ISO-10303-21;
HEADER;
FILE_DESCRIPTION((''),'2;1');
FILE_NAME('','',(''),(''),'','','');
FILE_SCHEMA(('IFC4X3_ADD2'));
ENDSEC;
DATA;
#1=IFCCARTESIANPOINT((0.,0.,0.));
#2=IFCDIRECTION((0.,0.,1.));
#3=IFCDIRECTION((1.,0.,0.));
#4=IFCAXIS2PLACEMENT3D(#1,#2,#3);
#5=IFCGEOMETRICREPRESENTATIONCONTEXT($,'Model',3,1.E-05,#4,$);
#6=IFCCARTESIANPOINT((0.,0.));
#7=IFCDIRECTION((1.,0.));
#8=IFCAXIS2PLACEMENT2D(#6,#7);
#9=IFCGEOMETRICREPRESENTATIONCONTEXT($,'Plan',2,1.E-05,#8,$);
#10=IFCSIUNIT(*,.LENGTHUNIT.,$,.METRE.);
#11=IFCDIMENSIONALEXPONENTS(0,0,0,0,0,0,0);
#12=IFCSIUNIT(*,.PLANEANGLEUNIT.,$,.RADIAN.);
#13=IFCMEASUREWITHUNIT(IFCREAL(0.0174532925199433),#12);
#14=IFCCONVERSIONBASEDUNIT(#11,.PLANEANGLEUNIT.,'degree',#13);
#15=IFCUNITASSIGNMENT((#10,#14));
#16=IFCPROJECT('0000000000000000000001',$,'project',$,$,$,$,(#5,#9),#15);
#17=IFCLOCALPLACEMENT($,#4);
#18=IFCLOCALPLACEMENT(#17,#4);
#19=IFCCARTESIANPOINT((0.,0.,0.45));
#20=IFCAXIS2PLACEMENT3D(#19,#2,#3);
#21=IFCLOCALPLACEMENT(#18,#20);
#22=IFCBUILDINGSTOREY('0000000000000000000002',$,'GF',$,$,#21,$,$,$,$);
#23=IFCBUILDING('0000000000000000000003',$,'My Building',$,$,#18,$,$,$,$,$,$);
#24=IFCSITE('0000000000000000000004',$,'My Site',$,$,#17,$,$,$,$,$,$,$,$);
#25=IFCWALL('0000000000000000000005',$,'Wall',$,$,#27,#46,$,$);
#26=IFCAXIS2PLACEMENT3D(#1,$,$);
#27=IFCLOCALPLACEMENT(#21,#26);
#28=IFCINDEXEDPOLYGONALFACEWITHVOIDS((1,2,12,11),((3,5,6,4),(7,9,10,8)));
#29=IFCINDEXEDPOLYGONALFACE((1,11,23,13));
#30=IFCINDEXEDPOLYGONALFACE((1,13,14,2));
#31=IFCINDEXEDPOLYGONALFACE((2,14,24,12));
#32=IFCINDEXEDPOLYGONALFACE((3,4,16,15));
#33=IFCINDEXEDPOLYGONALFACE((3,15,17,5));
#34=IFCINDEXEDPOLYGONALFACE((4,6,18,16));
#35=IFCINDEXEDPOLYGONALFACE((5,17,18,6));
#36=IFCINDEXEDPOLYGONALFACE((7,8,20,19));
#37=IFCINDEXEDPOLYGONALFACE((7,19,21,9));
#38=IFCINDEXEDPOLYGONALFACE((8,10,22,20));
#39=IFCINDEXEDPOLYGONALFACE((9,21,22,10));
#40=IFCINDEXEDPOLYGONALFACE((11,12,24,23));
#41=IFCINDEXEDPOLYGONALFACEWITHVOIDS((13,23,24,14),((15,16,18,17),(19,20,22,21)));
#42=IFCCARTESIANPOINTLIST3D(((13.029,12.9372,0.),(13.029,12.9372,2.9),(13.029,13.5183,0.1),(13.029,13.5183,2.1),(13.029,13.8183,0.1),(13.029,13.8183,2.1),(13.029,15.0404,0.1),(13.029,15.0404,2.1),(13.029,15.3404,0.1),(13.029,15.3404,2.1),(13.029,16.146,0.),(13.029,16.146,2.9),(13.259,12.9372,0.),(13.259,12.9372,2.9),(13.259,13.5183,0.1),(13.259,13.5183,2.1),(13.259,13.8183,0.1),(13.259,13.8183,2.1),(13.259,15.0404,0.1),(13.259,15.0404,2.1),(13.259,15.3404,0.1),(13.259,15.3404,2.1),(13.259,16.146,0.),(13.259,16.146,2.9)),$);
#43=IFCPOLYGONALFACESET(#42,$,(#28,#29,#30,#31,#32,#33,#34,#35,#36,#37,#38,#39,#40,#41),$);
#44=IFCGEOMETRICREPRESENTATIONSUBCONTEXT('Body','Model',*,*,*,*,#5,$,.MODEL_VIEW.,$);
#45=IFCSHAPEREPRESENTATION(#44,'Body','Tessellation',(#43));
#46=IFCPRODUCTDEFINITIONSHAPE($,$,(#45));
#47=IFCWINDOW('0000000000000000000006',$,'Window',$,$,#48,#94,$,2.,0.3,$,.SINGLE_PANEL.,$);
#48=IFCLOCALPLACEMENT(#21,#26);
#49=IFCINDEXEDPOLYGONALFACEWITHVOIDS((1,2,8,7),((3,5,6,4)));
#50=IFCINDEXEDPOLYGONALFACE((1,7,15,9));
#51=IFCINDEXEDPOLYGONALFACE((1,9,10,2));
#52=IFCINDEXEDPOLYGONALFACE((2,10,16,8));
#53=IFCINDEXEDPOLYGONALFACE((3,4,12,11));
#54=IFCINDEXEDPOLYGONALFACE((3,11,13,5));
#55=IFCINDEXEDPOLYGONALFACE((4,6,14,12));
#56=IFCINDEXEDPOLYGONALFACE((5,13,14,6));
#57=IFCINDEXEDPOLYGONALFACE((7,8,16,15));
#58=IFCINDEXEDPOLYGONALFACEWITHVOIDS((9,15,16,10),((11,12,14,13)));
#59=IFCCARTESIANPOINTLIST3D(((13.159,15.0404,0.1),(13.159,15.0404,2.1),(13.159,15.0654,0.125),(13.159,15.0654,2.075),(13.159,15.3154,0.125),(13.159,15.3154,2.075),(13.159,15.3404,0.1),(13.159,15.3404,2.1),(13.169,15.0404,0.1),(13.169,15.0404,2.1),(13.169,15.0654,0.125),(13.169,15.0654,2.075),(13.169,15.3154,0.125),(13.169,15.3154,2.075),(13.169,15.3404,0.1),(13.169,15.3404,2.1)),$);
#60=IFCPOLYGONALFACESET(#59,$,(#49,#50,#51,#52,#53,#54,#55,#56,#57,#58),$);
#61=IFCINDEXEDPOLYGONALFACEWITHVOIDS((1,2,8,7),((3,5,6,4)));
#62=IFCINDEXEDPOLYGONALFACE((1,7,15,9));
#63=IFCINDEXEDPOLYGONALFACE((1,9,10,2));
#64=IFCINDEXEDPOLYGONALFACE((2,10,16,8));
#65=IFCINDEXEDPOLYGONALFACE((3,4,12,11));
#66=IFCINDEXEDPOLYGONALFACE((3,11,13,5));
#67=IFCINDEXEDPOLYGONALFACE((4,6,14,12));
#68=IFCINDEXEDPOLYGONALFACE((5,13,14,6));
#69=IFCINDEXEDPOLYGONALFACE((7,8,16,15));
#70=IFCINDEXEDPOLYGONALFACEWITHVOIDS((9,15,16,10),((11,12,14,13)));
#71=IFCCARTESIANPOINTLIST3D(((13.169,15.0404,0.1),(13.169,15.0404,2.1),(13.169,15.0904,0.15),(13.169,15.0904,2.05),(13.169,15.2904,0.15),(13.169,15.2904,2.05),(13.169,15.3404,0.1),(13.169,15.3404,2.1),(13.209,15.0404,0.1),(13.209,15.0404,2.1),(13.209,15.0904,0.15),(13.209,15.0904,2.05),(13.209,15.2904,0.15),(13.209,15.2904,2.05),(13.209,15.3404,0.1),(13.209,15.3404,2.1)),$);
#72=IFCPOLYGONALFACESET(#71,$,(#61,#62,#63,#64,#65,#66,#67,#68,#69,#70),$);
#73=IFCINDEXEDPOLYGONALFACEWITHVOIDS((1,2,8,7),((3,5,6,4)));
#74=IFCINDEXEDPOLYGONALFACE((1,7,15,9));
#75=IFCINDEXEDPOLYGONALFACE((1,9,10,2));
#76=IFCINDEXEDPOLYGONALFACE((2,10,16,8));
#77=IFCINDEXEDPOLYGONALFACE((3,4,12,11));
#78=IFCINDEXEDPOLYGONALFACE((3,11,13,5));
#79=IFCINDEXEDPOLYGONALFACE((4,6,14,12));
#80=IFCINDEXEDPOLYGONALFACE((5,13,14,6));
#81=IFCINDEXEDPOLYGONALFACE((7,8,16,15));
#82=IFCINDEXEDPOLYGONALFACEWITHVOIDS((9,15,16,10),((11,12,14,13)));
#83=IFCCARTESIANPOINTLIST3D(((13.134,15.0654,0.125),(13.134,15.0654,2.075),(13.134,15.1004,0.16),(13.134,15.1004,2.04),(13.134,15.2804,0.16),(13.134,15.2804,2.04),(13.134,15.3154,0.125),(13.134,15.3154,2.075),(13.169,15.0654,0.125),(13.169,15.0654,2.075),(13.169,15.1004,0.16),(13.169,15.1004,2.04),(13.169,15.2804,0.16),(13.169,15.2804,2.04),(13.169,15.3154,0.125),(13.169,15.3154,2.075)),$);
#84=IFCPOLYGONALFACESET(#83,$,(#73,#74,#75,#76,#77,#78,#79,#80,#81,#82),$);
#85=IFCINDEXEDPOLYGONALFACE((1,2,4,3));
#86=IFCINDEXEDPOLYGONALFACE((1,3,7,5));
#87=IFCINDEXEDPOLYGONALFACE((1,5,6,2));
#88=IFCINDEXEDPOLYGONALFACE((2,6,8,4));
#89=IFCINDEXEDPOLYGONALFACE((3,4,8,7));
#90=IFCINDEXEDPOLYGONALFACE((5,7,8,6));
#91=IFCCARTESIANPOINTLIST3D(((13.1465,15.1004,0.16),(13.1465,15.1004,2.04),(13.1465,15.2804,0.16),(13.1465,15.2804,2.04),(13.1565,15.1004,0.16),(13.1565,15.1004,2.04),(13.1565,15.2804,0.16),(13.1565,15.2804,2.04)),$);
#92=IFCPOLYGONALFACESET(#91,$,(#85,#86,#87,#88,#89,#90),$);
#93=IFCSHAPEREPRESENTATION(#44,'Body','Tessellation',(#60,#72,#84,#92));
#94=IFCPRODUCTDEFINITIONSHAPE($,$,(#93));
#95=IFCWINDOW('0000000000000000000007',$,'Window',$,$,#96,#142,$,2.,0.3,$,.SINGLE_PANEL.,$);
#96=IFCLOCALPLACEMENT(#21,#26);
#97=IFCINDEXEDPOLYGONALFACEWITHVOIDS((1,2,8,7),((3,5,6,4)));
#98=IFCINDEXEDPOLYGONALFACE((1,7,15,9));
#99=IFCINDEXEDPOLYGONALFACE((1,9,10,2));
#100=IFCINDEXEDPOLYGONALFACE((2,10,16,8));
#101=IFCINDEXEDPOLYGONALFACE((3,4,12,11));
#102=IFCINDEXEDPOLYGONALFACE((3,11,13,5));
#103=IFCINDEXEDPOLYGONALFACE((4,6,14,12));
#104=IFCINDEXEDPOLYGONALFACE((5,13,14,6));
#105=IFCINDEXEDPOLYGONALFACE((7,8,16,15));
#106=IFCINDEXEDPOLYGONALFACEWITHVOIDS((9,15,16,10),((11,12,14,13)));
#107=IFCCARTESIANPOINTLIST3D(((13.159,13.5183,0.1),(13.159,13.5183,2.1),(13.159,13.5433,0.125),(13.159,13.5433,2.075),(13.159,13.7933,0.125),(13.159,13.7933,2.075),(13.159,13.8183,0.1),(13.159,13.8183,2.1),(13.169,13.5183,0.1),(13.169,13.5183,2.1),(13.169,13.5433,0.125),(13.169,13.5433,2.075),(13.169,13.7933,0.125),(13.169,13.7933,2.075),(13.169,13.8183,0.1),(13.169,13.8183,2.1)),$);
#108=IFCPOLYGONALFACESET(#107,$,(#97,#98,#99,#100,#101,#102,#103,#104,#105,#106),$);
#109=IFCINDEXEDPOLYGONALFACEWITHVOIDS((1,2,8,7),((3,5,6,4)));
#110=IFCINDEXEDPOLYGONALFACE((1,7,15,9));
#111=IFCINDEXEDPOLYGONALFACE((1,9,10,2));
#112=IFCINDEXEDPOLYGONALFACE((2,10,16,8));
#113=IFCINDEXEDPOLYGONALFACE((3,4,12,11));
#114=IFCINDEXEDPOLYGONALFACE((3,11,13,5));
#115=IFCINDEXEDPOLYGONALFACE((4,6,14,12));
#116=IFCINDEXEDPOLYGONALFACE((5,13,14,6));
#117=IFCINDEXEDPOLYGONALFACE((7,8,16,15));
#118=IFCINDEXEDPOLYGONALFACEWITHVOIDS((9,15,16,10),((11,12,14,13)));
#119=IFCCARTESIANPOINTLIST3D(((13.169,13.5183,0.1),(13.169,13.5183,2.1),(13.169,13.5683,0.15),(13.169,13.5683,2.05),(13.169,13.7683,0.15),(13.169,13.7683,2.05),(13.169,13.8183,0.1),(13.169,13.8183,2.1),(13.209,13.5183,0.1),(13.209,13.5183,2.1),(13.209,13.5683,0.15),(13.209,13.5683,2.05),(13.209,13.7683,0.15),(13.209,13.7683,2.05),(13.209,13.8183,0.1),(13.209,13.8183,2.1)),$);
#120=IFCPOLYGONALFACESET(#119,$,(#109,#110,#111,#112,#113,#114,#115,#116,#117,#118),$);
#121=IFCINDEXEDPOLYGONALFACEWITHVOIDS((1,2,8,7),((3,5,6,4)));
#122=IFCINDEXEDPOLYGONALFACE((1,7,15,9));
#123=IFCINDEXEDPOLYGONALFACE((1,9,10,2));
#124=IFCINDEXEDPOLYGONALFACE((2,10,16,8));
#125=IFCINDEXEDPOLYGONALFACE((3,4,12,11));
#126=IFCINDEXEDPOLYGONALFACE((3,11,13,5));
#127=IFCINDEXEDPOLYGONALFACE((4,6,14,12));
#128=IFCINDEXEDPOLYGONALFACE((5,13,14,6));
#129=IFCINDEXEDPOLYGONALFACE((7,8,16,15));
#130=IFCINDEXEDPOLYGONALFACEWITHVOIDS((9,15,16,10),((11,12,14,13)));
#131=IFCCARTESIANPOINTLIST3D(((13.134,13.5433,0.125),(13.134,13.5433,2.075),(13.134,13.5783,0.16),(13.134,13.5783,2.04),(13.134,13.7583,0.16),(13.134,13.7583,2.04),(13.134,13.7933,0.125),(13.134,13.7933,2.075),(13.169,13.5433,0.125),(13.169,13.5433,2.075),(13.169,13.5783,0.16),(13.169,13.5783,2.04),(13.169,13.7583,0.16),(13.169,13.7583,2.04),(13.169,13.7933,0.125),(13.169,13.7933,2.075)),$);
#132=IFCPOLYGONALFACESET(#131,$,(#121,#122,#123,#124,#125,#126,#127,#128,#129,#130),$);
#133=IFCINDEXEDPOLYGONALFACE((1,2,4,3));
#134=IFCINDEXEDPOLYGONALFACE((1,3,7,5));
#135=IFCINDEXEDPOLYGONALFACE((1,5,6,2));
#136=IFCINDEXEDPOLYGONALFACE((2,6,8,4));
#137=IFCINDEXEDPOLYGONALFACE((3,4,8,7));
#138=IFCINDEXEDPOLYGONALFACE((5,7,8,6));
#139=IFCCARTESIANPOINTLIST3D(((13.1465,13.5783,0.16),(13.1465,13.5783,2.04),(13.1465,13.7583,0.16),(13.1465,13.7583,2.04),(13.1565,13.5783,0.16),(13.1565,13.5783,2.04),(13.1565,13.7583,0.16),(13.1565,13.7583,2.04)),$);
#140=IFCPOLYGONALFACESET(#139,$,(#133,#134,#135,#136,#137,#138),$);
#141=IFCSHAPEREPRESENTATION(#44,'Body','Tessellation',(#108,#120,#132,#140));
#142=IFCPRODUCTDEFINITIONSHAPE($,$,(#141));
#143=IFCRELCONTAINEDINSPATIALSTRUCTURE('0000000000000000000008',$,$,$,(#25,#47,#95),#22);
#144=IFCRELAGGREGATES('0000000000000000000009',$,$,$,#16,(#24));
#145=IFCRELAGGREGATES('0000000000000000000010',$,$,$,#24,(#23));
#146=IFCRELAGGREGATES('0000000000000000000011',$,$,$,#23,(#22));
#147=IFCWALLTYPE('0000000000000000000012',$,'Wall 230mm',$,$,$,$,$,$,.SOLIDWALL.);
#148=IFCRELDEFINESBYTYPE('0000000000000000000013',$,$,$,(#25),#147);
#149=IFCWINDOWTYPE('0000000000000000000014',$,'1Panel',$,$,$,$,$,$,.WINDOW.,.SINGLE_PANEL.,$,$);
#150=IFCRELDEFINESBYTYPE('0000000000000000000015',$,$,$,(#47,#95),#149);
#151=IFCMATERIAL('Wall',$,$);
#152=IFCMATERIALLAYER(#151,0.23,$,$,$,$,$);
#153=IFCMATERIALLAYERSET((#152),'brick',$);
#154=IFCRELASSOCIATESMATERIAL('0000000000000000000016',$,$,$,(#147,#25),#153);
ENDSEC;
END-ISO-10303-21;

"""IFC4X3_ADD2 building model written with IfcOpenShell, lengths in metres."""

from ifc_helpers import new_model, entity, si_unit, converted_unit, frame, origin_with_axes, origin_2d_with_axis, place, context, subcontext, project, spatial, line, indexed_curve, outline, extrude, shape, source, transform, mapped, material, layer, layer_set, layer_usage, type_object, type_shapes, element, fill, save


model = new_model("IFC4X3_ADD2")

# Units and contexts
model_context = context("Model", 3, precision=1e-05, world=origin_with_axes())
plan_context = context("Plan", 2, precision=1e-05, world=origin_2d_with_axis())
body_context_1 = subcontext(model_context, "Body", "Model", "MODEL_VIEW")
body_context_2 = subcontext(plan_context, "Body", "Plan", "PLAN_VIEW")
ifc_project = project(units=[si_unit("LENGTHUNIT", "METRE"), converted_unit("PLANEANGLEUNIT", "degree", entity("IfcReal", 0.0174532925199433), si_unit("PLANEANGLEUNIT", "RADIAN"), dimensions=[0, 0, 0, 0, 0, 0, 0])], contexts=[model_context, plan_context])

# Site, building, storey
site_placement = place(None, origin_with_axes())
site = spatial("IfcSite", under=ifc_project, at=site_placement, Name="My Site")
building_placement = place(site_placement, origin_with_axes())
building = spatial("IfcBuilding", under=site, at=building_placement, Name="My Building")
storey_placement = place(building_placement, frame((0.0, 0.0, 0.45), z_axis=(0.0, 0.0, 1.0), x_axis=(1.0, 0.0, 0.0)))
storey = spatial("IfcBuildingStorey", under=building, at=storey_placement, Name="GF")

# Shared definitions
ifc_material_1 = material(Name="Wall")
ifc_layer = layer(ifc_material_1, 0.23)
ifc_layer_set = layer_set([ifc_layer], Name="brick")
wall_type = type_object("IfcWallType", Name="Wall 230mm", PredefinedType="SOLIDWALL", material=ifc_layer_set)

# Wall, openings, windows
ifc_layer_usage_1 = layer_usage(ifc_layer_set, "AXIS2", "POSITIVE", 0.0)
wall_1_placement = place(storey_placement, frame((13.259, 12.9372, 0.0), z_axis=(0.0, 0.0, 1.0), x_axis=(0.0, 1.0, 0.0)))
wall_1 = element("IfcWall", 1, at=wall_1_placement, inside=storey, type_object=wall_type, material=ifc_layer_usage_1, Name="Wall", context=body_context_1, shape_type="SweptSolid", body=[
    extrude(outline(indexed_curve([(0.0, 0.0), (0.0, 0.23), (3.2088, 0.23), (3.2088, 0.0), (0.0, 0.0)], self_intersect=False)), origin_with_axes(), (0.0, 0.0, 1.0), 2.9),
])
shared_shape_1 = source(origin_with_axes(), body_context_1, "Body", "SweptSolid", [
    extrude(outline(indexed_curve([(0.0, 0.0), (0.3, 0.0), (0.3, 2.0), (0.0, 2.0)], segments=[line(1, 2, 3, 4, 1)])), frame((0.0, -0.6, 0.0), z_axis=(0.0, -1.0, 0.0), x_axis=(1.0, 0.0, 0.0)), (0.0, 0.0, -1.0), 1.2),
])
opening_1_placement = place(wall_1_placement, frame((2.1032, 0.0, 0.1), z_axis=(0.0, 0.0, 1.0), x_axis=(1.0, 0.0, 0.0)))
opening_1 = element("IfcOpeningElement", 2, at=opening_1_placement, cuts=wall_1, PredefinedType="OPENING", context=body_context_1, shape_type="MappedRepresentation", body=[
    mapped(shared_shape_1, transform((0.0, 0.0, 0.0), x_axis=(1.0, 0.0, 0.0), y_axis=(0.0, 1.0, 0.0), z_axis=(0.0, 0.0, 1.0), scale=1.0)),
])
opening_2_placement = place(wall_1_placement, frame((0.5811, 0.0, 0.1), z_axis=(0.0, 0.0, 1.0), x_axis=(1.0, 0.0, 0.0)))
opening_2 = element("IfcOpeningElement", 3, at=opening_2_placement, cuts=wall_1, PredefinedType="OPENING", context=body_context_1, shape_type="MappedRepresentation", body=[
    mapped(shared_shape_1, transform((0.0, 0.0, 0.0), x_axis=(1.0, 0.0, 0.0), y_axis=(0.0, 1.0, 0.0), z_axis=(0.0, 0.0, 1.0), scale=1.0)),
])
window_type_1 = type_object("IfcWindowType", Name="1Panel", PartitioningType="SINGLE_PANEL", PredefinedType="WINDOW")
shared_shape_2 = source(origin_with_axes(), body_context_1, "Body", "SweptSolid", [
    extrude(outline(indexed_curve([(0.0, 0.0), (0.3, 0.0), (0.3, 2.0), (0.0, 2.0)], segments=[line(1, 2, 3, 4, 1)]), holes=[indexed_curve([(0.025, 0.025), (0.275, 0.025), (0.275, 1.975), (0.025, 1.975)], segments=[line(1, 2, 3, 4, 1)])]), frame((0.0, 0.09, 0.0), z_axis=(0.0, -1.0, 0.0), x_axis=(1.0, 0.0, 0.0)), (0.0, 0.0, -1.0), 0.01),
    extrude(outline(indexed_curve([(0.0, 0.0), (0.3, 0.0), (0.3, 2.0), (0.0, 2.0)], segments=[line(1, 2, 3, 4, 1)]), holes=[indexed_curve([(0.05, 0.05), (0.25, 0.05), (0.25, 1.95), (0.05, 1.95)], segments=[line(1, 2, 3, 4, 1)])]), frame((0.0, 0.05, 0.0), z_axis=(0.0, -1.0, 0.0), x_axis=(1.0, 0.0, 0.0)), (0.0, 0.0, -1.0), 0.04),
    extrude(outline(indexed_curve([(0.0, 0.0), (0.25, 0.0), (0.25, 1.95), (0.0, 1.95)], segments=[line(1, 2, 3, 4, 1)]), holes=[indexed_curve([(0.035, 0.035), (0.215, 0.035), (0.215, 1.915), (0.035, 1.915)], segments=[line(1, 2, 3, 4, 1)])]), frame((0.025, 0.09, 0.025), z_axis=(0.0, -1.0, 0.0), x_axis=(1.0, 0.0, 0.0)), (0.0, 0.0, -1.0), 0.035),
    extrude(outline(indexed_curve([(0.035, 0.035), (0.215, 0.035), (0.215, 1.915), (0.035, 1.915)], segments=[line(1, 2, 3, 4, 1)])), frame((0.025, 0.1025, 0.025), z_axis=(0.0, -1.0, 0.0), x_axis=(1.0, 0.0, 0.0)), (0.0, 0.0, -1.0), 0.01),
])
shared_shape_3 = source(origin_with_axes(), body_context_2, "Body", "Curve2D", [
    entity("IfcIndexedPolyCurve", entity("IfcCartesianPointList2D", [[0.05, 0.05], [0.25, 0.05]])),
    entity("IfcIndexedPolyCurve", entity("IfcCartesianPointList2D", [[0.0, 0.1], [0.025, 0.1], [0.025, 0.09], [0.05, 0.09], [0.05, 0.05], [0.0, 0.05]]), [entity("IfcLineIndex", [1, 2, 3, 4, 5, 6, 1])]),
    entity("IfcIndexedPolyCurve", entity("IfcCartesianPointList2D", [[0.3, 0.1], [0.275, 0.1], [0.275, 0.09], [0.25, 0.09], [0.25, 0.05], [0.3, 0.05]]), [entity("IfcLineIndex", [1, 2, 3, 4, 5, 6, 1])]),
    entity("IfcIndexedPolyCurve", entity("IfcCartesianPointList2D", [[0.025, 0.09], [0.06, 0.09], [0.06, 0.125], [0.025, 0.125]]), [entity("IfcLineIndex", [1, 2, 3, 4, 1])]),
    entity("IfcIndexedPolyCurve", entity("IfcCartesianPointList2D", [[0.275, 0.09], [0.24, 0.09], [0.24, 0.125], [0.275, 0.125]]), [entity("IfcLineIndex", [1, 2, 3, 4, 1])]),
    entity("IfcIndexedPolyCurve", entity("IfcCartesianPointList2D", [[0.06, 0.09], [0.24, 0.09]])),
    entity("IfcIndexedPolyCurve", entity("IfcCartesianPointList2D", [[0.06, 0.125], [0.24, 0.125]])),
    entity("IfcIndexedPolyCurve", entity("IfcCartesianPointList2D", [[0.06, 0.1075], [0.24, 0.1075]])),
])
type_shapes(window_type_1, [shared_shape_2, shared_shape_3])
window_1_placement = place(opening_1_placement, frame((0.0, 0.0, 0.0), z_axis=(0.0, 0.0, 1.0), x_axis=(1.0, 0.0, 0.0)))
window_1 = element("IfcWindow", 4, at=window_1_placement, inside=storey, type_object=window_type_1, Name="Window", OverallHeight=2.0, OverallWidth=0.3, PartitioningType="SINGLE_PANEL", shapes=[
    shape(body_context_1, "Body", "MappedRepresentation", [mapped(shared_shape_2, transform((0.0, 0.0, 0.0), x_axis=(1.0, 0.0, 0.0), y_axis=(0.0, 1.0, 0.0), z_axis=(0.0, 0.0, 1.0), scale=1.0))]),
    shape(body_context_2, "Body", "MappedRepresentation", [mapped(shared_shape_3, transform((0.0, 0.0, 0.0), x_axis=(1.0, 0.0, 0.0), y_axis=(0.0, 1.0, 0.0), z_axis=(0.0, 0.0, 1.0), scale=1.0))]),
])
fill(opening_1, window_1)
window_2_placement = place(opening_2_placement, frame((0.0, 0.0, 0.0), z_axis=(0.0, 0.0, 1.0), x_axis=(1.0, 0.0, 0.0)))
window_2 = element("IfcWindow", 5, at=window_2_placement, inside=storey, type_object=window_type_1, Name="Window", OverallHeight=2.0, OverallWidth=0.3, PartitioningType="SINGLE_PANEL", shapes=[
    shape(body_context_1, "Body", "MappedRepresentation", [mapped(shared_shape_2, transform((0.0, 0.0, 0.0), x_axis=(1.0, 0.0, 0.0), y_axis=(0.0, 1.0, 0.0), z_axis=(0.0, 0.0, 1.0), scale=1.0))]),
    shape(body_context_2, "Body", "MappedRepresentation", [mapped(shared_shape_3, transform((0.0, 0.0, 0.0), x_axis=(1.0, 0.0, 0.0), y_axis=(0.0, 1.0, 0.0), z_axis=(0.0, 0.0, 1.0), scale=1.0))]),
])
fill(opening_2, window_2)

save(model, "model.ifc")
